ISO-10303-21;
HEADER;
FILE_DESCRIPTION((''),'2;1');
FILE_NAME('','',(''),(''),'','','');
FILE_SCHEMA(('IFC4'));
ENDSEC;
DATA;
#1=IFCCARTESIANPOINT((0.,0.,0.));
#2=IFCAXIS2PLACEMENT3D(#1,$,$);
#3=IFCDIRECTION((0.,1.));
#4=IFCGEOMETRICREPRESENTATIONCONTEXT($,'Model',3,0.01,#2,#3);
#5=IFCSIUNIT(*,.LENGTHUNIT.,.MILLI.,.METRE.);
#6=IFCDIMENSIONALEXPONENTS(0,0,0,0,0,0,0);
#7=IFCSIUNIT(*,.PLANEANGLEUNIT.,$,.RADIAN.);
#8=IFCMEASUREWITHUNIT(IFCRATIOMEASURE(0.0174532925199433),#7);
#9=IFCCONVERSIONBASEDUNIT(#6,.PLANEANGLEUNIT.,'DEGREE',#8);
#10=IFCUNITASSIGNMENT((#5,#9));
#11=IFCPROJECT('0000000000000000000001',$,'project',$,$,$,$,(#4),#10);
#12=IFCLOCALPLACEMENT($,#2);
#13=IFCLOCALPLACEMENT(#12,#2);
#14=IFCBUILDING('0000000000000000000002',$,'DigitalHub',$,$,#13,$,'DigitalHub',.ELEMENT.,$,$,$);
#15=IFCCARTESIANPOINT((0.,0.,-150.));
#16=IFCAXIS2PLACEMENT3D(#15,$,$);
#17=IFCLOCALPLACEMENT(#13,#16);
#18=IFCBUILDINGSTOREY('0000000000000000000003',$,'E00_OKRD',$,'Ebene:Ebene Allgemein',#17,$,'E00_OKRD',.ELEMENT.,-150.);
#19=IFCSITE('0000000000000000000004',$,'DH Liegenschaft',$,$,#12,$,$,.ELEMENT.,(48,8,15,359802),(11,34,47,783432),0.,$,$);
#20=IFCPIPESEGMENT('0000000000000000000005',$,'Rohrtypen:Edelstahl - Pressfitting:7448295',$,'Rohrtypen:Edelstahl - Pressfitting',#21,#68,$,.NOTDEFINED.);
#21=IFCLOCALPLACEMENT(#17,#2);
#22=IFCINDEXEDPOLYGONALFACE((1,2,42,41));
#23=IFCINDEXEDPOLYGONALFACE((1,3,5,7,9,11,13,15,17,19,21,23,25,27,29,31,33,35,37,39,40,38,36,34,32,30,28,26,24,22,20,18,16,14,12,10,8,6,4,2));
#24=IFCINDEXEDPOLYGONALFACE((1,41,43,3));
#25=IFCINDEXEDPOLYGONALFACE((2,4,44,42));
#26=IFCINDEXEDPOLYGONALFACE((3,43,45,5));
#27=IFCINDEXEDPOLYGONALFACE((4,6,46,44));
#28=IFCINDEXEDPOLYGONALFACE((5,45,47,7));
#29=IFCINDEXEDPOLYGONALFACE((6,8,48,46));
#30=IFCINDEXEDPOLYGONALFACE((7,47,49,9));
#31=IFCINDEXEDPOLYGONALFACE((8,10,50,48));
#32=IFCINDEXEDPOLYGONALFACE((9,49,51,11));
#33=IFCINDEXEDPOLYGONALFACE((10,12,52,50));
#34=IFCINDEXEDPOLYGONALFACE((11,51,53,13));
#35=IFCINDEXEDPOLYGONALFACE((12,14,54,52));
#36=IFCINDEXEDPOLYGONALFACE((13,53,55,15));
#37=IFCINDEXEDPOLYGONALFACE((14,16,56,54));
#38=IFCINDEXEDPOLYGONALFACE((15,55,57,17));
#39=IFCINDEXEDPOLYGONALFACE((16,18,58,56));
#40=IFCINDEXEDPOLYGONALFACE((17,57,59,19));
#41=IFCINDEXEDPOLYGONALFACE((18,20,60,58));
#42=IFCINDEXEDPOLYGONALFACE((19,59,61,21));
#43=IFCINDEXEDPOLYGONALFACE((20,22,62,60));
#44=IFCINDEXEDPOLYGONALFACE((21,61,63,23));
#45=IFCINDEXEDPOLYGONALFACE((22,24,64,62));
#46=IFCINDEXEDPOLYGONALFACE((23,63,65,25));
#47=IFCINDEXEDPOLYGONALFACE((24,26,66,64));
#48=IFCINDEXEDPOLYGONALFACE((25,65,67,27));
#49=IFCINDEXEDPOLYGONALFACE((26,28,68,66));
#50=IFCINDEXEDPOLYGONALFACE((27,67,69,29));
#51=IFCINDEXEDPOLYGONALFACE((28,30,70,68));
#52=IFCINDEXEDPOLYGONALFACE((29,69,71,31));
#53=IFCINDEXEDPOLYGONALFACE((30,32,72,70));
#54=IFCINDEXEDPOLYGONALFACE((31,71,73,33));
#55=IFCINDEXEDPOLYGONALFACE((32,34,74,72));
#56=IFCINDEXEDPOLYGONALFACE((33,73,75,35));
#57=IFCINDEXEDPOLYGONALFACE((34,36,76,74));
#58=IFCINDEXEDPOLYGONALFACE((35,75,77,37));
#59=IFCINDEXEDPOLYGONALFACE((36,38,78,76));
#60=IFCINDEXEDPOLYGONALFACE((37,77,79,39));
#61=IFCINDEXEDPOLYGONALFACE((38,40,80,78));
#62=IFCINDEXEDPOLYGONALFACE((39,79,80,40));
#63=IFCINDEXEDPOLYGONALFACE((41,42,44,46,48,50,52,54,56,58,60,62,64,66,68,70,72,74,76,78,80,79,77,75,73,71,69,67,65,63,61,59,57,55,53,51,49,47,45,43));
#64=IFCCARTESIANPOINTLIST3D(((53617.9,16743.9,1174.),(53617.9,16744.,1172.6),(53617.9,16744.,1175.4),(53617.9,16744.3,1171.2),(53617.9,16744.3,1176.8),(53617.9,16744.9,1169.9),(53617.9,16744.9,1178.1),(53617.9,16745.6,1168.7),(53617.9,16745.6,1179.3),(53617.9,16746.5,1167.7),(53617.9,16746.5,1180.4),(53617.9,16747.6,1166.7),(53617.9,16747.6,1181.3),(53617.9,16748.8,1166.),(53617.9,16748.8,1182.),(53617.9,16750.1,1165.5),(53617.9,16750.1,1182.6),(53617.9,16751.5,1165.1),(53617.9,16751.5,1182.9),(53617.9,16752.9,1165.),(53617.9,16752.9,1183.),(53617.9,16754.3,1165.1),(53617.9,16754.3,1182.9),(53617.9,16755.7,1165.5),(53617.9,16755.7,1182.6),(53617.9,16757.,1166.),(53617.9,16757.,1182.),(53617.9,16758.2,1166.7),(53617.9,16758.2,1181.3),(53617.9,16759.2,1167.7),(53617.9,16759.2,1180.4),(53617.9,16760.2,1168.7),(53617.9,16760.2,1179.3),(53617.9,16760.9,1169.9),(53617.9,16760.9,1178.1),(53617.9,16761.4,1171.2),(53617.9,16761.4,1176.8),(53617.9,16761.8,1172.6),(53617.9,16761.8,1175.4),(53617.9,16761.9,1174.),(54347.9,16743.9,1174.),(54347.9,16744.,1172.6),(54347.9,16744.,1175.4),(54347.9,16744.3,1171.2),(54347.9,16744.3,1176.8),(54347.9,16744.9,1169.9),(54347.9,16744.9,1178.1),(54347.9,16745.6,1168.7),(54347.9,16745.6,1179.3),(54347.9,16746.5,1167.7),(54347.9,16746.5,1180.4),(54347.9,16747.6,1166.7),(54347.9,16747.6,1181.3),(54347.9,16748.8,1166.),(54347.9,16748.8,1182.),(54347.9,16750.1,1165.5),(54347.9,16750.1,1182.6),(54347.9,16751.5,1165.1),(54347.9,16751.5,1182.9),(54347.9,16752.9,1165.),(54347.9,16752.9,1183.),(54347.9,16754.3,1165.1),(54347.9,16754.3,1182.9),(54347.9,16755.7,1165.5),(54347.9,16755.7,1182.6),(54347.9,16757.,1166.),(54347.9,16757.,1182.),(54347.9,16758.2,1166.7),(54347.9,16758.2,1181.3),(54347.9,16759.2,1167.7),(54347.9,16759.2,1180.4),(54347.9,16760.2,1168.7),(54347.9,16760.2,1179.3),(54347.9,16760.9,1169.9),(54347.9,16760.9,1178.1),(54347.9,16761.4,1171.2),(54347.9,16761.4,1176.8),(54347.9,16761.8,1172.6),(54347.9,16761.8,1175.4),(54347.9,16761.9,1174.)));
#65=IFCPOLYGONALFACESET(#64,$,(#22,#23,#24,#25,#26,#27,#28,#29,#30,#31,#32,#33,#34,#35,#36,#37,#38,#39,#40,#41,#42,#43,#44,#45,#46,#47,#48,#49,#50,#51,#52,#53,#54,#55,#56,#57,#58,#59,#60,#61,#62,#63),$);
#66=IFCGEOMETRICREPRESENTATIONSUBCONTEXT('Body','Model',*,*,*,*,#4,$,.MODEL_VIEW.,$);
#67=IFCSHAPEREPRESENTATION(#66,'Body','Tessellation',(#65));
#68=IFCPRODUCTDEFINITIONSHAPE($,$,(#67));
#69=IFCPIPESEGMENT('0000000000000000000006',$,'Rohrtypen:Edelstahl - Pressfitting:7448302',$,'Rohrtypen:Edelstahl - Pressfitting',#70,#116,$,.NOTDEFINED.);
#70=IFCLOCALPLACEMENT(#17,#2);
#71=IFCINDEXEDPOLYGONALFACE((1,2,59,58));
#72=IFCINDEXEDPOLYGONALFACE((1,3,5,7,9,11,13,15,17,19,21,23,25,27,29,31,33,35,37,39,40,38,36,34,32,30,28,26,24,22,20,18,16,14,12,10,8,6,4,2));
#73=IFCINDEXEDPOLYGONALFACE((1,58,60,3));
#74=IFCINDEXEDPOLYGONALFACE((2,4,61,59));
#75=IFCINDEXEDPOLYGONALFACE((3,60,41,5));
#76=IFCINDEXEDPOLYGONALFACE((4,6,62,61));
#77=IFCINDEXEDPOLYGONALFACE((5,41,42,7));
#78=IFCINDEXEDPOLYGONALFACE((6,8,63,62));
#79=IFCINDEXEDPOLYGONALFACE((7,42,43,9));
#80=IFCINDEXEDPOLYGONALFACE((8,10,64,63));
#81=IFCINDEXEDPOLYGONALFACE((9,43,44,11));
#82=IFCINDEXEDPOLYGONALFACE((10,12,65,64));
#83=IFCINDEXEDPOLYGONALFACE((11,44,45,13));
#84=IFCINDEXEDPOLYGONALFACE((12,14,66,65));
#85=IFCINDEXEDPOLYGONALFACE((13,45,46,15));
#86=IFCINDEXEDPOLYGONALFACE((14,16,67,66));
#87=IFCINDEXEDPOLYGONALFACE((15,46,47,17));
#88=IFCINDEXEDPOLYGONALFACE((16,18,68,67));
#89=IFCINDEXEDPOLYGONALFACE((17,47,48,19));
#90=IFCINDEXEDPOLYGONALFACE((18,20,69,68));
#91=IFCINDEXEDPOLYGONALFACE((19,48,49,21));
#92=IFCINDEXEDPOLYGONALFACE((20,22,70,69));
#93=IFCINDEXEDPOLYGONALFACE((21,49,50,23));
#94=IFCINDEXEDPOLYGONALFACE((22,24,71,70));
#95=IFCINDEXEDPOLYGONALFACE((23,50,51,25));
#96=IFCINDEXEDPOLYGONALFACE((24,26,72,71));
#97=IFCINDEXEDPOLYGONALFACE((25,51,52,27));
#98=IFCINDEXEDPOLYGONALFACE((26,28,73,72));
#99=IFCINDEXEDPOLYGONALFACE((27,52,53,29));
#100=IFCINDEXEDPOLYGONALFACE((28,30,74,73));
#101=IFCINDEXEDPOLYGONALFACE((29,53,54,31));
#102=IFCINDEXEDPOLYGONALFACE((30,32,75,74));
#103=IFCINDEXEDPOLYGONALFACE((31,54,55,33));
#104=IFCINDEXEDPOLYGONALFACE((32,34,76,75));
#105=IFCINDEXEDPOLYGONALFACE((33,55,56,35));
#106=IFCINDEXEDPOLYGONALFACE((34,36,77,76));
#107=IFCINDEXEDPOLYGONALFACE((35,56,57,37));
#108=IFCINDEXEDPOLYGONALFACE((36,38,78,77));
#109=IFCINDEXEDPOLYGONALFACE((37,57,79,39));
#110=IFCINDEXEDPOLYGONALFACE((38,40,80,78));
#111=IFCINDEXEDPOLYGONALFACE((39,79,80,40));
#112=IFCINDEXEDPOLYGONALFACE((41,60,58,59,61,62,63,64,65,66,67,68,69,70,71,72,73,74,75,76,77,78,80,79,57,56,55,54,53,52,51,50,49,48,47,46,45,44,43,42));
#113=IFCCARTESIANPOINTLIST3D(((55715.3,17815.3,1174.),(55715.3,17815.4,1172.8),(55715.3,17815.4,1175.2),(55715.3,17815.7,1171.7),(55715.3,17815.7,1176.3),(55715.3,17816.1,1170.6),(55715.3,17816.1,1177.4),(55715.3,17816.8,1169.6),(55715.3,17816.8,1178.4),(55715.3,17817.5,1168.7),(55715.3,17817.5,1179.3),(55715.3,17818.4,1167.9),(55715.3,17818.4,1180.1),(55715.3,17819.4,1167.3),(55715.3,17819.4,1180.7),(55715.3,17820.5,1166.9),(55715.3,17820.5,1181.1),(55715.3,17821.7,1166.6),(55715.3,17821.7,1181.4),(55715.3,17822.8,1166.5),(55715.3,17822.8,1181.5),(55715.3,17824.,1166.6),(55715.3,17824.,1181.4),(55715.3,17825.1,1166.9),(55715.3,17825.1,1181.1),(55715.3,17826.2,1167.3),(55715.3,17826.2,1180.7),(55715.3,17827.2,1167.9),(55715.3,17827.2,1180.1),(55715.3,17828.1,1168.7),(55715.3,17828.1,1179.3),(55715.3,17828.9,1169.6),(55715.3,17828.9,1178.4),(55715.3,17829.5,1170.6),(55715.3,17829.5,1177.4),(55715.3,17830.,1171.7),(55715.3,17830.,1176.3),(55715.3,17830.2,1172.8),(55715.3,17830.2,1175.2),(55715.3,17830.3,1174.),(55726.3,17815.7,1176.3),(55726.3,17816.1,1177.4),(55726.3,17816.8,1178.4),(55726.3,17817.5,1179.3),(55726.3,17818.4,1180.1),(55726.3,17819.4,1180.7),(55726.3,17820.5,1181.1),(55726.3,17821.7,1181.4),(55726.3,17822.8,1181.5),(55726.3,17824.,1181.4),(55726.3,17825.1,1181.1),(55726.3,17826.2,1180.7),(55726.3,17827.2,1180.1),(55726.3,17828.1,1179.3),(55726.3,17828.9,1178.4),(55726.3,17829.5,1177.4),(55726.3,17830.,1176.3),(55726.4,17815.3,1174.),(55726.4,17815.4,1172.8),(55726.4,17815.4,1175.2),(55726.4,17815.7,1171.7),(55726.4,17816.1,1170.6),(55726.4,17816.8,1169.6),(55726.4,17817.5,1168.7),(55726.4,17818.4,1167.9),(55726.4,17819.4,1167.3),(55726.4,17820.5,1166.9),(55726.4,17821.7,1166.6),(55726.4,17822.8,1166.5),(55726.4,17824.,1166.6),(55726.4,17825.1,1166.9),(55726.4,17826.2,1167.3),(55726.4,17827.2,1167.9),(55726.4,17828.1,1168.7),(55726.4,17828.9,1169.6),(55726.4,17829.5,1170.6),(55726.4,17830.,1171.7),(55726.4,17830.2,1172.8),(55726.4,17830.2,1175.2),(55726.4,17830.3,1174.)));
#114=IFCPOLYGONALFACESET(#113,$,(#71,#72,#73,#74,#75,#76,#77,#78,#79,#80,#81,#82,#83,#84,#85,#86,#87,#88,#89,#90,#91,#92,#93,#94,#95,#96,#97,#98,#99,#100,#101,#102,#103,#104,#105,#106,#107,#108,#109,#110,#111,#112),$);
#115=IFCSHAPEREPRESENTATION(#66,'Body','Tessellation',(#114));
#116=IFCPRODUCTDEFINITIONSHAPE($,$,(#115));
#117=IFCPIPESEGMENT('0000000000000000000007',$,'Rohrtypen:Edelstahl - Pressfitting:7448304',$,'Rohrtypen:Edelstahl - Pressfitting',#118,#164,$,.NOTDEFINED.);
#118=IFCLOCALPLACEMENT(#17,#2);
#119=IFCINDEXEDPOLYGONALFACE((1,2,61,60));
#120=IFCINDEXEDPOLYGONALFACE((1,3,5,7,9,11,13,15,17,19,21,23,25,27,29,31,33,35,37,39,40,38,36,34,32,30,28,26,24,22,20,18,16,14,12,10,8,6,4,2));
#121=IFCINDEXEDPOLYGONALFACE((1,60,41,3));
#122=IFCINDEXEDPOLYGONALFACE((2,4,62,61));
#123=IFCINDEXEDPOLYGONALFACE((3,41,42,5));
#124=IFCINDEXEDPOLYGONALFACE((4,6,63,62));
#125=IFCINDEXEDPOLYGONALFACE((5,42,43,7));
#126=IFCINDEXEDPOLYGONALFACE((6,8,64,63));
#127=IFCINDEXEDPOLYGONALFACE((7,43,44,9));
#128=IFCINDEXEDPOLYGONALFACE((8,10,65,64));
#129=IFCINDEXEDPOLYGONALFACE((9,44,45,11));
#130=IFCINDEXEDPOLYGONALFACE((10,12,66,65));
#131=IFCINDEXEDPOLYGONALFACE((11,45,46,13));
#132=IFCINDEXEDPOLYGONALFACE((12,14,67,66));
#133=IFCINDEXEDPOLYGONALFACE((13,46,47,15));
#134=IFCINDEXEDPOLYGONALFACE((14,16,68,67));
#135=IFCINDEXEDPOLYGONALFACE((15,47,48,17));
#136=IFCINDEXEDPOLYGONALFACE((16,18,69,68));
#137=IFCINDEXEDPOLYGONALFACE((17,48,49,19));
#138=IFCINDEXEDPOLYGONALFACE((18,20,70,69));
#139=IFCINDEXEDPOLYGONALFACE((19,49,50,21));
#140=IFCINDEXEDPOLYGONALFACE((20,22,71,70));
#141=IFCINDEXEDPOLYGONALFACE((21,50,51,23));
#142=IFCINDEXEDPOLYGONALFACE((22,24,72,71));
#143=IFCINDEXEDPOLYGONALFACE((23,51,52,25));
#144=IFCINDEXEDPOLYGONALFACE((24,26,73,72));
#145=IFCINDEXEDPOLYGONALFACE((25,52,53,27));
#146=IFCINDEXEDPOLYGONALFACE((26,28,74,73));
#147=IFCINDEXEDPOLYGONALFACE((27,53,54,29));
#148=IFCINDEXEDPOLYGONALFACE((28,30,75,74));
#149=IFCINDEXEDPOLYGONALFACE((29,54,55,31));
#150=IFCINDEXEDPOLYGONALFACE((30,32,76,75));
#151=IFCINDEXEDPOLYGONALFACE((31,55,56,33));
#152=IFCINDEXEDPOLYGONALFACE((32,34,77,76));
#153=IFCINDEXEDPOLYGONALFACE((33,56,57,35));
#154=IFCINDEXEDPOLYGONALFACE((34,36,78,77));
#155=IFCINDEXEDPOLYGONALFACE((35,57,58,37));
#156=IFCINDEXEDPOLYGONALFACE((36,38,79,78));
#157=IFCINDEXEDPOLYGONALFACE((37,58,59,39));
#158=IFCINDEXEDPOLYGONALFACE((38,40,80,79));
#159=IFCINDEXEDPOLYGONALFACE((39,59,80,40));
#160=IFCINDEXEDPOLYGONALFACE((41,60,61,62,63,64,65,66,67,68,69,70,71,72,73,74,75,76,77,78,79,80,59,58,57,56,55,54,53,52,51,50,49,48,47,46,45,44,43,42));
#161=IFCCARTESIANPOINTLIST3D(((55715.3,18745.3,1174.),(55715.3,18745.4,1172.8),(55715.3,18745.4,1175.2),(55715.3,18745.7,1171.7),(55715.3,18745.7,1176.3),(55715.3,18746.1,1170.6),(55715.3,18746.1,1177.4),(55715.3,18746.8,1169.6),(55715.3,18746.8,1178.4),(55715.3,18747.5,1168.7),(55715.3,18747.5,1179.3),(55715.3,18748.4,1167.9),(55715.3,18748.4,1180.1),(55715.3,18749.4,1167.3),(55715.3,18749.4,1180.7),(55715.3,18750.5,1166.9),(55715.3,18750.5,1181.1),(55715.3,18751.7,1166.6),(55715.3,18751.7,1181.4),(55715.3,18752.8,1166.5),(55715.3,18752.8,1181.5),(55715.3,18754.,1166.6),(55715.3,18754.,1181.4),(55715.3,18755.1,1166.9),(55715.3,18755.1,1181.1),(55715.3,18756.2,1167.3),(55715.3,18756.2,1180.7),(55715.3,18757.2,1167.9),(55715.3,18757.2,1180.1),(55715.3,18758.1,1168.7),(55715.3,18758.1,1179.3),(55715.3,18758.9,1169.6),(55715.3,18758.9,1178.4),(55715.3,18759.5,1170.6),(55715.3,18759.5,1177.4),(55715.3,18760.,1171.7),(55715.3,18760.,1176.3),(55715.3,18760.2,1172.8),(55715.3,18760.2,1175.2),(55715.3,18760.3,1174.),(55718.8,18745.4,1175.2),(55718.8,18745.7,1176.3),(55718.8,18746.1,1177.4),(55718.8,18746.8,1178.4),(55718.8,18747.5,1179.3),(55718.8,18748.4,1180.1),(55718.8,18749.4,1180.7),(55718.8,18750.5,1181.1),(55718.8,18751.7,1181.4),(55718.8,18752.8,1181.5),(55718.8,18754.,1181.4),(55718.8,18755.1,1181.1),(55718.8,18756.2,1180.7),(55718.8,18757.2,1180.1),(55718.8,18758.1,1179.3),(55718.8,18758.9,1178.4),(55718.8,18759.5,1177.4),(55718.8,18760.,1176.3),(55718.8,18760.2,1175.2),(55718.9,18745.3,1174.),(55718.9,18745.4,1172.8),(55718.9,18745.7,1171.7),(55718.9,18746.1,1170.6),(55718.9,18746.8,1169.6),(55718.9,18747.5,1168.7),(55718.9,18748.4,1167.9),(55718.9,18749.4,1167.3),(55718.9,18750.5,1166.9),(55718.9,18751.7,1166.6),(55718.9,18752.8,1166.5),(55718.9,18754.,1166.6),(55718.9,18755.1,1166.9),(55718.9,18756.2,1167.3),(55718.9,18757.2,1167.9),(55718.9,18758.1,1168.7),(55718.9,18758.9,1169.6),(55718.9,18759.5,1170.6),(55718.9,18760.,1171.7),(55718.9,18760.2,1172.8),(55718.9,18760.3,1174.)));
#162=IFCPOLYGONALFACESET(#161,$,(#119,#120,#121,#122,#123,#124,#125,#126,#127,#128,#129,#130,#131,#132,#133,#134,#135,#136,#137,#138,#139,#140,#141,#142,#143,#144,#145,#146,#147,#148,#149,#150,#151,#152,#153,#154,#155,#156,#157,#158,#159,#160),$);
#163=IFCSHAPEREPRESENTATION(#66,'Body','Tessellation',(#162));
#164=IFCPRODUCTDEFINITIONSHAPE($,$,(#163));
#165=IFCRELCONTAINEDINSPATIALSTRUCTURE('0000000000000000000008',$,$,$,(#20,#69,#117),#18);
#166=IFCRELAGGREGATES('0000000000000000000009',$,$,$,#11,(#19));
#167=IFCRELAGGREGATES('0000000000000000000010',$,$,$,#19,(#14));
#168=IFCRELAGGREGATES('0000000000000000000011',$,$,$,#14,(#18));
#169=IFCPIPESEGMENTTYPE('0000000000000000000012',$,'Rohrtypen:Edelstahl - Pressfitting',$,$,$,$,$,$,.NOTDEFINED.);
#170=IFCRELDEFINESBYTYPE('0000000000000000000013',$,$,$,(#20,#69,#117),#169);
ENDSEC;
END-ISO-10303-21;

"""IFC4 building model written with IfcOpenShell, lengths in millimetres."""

from ifc_helpers import new_model, entity, si_unit, converted_unit, direction, frame, origin, place, context, subcontext, project, spatial, indexed_curve, outline, extrude, type_object, element, save


model = new_model("IFC4")

# Units and contexts
model_context = context("Model", 3, precision=0.01, world=origin(), true_north=direction((0.0, 1.0)))
body_context = subcontext(model_context, "Body", "Model", "MODEL_VIEW")
ifc_project = project(units=[si_unit("LENGTHUNIT", "METRE", prefix="MILLI"), converted_unit("PLANEANGLEUNIT", "DEGREE", entity("IfcRatioMeasure", 0.0174532925199433), si_unit("PLANEANGLEUNIT", "RADIAN"), dimensions=[0, 0, 0, 0, 0, 0, 0])], contexts=[model_context])

# Site, building, storey
site_placement = place(None, origin())
site = spatial("IfcSite", under=ifc_project, at=site_placement, Name="DH Liegenschaft", CompositionType="ELEMENT", RefLatitude=(48, 8, 15, 359802), RefLongitude=(11, 34, 47, 783432), RefElevation=0.0)
building_placement = place(site_placement, origin())
building = spatial("IfcBuilding", under=site, at=building_placement, Name="DigitalHub", LongName="DigitalHub", CompositionType="ELEMENT")
storey_placement = place(building_placement, frame((0.0, 0.0, -150.0)))
storey = spatial("IfcBuildingStorey", under=building, at=storey_placement, Name="E00_OKRD", ObjectType="Ebene:Ebene Allgemein", LongName="E00_OKRD", CompositionType="ELEMENT", Elevation=-150.0)

# Pipe segments
pipe_segment_type_1 = type_object("IfcPipeSegmentType", Name="Rohrtypen:Edelstahl - Pressfitting", PredefinedType="NOTDEFINED")
pipe_segment_1_placement = place(storey_placement, frame((53617.9, 16742.3, 1163.4)))
element("IfcPipeSegment", 1, at=pipe_segment_1_placement, inside=storey, type_object=pipe_segment_type_1, Name="Rohrtypen:Edelstahl - Pressfitting:7448295", ObjectType="Rohrtypen:Edelstahl - Pressfitting", PredefinedType="NOTDEFINED", context=body_context, shape_type="SweptSolid", body=[
    extrude(outline(indexed_curve([(9.0, 0.0), (8.9, 1.4), (8.6, 2.8), (8.0, 4.1), (7.3, 5.3), (6.4, 6.4), (5.3, 7.3), (4.1, 8.0), (2.8, 8.6), (1.4, 8.9), (0.0, 9.0), (-1.4, 8.9), (-2.8, 8.6), (-4.1, 8.0), (-5.3, 7.3), (-6.4, 6.4), (-7.3, 5.3), (-8.0, 4.1), (-8.6, 2.8), (-8.9, 1.4), (-9.0, 0.0), (-8.9, -1.4), (-8.6, -2.8), (-8.0, -4.1), (-7.3, -5.3), (-6.4, -6.4), (-5.3, -7.3), (-4.1, -8.0), (-2.8, -8.6), (-1.4, -8.9), (0.0, -9.0), (1.4, -8.9), (2.8, -8.6), (4.1, -8.0), (5.3, -7.3), (6.4, -6.4), (7.3, -5.3), (8.0, -4.1), (8.6, -2.8), (8.9, -1.4), (9.0, 0.0)], self_intersect=False)), frame((0.0, 10.6, 10.6), z_axis=(1.0, 0.0, 0.0), x_axis=(0.0, -1.0, 0.0)), (0.0, 0.0, 1.0), 730.0),
])
pipe_segment_2_placement = place(storey_placement, frame((55715.3, 17813.7, 1164.9)))
element("IfcPipeSegment", 2, at=pipe_segment_2_placement, inside=storey, type_object=pipe_segment_type_1, Name="Rohrtypen:Edelstahl - Pressfitting:7448302", ObjectType="Rohrtypen:Edelstahl - Pressfitting", PredefinedType="NOTDEFINED", context=body_context, shape_type="SweptSolid", body=[
    extrude(outline(indexed_curve([(7.5, 0.0), (7.4, 1.2), (7.1, 2.3), (6.7, 3.4), (6.1, 4.4), (5.3, 5.3), (4.4, 6.1), (3.4, 6.7), (2.3, 7.1), (1.2, 7.4), (0.0, 7.5), (-1.2, 7.4), (-2.3, 7.1), (-3.4, 6.7), (-4.4, 6.1), (-5.3, 5.3), (-6.1, 4.4), (-6.7, 3.4), (-7.1, 2.3), (-7.4, 1.2), (-7.5, 0.0), (-7.4, -1.2), (-7.1, -2.3), (-6.7, -3.4), (-6.1, -4.4), (-5.3, -5.3), (-4.4, -6.1), (-3.4, -6.7), (-2.3, -7.1), (-1.2, -7.4), (0.0, -7.5), (1.2, -7.4), (2.3, -7.1), (3.4, -6.7), (4.4, -6.1), (5.3, -5.3), (6.1, -4.4), (6.7, -3.4), (7.1, -2.3), (7.4, -1.2), (7.5, 0.0)], self_intersect=False)), frame((0.0, 9.1, 9.1), z_axis=(0.999999, 0.0, 0.001254), x_axis=(0.0, 1.0, 0.0)), (0.0, 0.0, 1.0), 11.1),
])
pipe_segment_3_placement = place(storey_placement, frame((55715.3, 18743.7, 1164.9)))
element("IfcPipeSegment", 3, at=pipe_segment_3_placement, inside=storey, type_object=pipe_segment_type_1, Name="Rohrtypen:Edelstahl - Pressfitting:7448304", ObjectType="Rohrtypen:Edelstahl - Pressfitting", PredefinedType="NOTDEFINED", context=body_context, shape_type="SweptSolid", body=[
    extrude(outline(indexed_curve([(7.5, 0.0), (7.4, 1.2), (7.1, 2.3), (6.7, 3.4), (6.1, 4.4), (5.3, 5.3), (4.4, 6.1), (3.4, 6.7), (2.3, 7.1), (1.2, 7.4), (0.0, 7.5), (-1.2, 7.4), (-2.3, 7.1), (-3.4, 6.7), (-4.4, 6.1), (-5.3, 5.3), (-6.1, 4.4), (-6.7, 3.4), (-7.1, 2.3), (-7.4, 1.2), (-7.5, 0.0), (-7.4, -1.2), (-7.1, -2.3), (-6.7, -3.4), (-6.1, -4.4), (-5.3, -5.3), (-4.4, -6.1), (-3.4, -6.7), (-2.3, -7.1), (-1.2, -7.4), (0.0, -7.5), (1.2, -7.4), (2.3, -7.1), (3.4, -6.7), (4.4, -6.1), (5.3, -5.3), (6.1, -4.4), (6.7, -3.4), (7.1, -2.3), (7.4, -1.2), (7.5, 0.0)], self_intersect=False)), frame((0.0, 9.1, 9.1), z_axis=(0.999992, 0.0, 0.003988), x_axis=(0.0, 1.0, 0.0)), (0.0, 0.0, 1.0), 3.6),
])

save(model, "model.ifc")
